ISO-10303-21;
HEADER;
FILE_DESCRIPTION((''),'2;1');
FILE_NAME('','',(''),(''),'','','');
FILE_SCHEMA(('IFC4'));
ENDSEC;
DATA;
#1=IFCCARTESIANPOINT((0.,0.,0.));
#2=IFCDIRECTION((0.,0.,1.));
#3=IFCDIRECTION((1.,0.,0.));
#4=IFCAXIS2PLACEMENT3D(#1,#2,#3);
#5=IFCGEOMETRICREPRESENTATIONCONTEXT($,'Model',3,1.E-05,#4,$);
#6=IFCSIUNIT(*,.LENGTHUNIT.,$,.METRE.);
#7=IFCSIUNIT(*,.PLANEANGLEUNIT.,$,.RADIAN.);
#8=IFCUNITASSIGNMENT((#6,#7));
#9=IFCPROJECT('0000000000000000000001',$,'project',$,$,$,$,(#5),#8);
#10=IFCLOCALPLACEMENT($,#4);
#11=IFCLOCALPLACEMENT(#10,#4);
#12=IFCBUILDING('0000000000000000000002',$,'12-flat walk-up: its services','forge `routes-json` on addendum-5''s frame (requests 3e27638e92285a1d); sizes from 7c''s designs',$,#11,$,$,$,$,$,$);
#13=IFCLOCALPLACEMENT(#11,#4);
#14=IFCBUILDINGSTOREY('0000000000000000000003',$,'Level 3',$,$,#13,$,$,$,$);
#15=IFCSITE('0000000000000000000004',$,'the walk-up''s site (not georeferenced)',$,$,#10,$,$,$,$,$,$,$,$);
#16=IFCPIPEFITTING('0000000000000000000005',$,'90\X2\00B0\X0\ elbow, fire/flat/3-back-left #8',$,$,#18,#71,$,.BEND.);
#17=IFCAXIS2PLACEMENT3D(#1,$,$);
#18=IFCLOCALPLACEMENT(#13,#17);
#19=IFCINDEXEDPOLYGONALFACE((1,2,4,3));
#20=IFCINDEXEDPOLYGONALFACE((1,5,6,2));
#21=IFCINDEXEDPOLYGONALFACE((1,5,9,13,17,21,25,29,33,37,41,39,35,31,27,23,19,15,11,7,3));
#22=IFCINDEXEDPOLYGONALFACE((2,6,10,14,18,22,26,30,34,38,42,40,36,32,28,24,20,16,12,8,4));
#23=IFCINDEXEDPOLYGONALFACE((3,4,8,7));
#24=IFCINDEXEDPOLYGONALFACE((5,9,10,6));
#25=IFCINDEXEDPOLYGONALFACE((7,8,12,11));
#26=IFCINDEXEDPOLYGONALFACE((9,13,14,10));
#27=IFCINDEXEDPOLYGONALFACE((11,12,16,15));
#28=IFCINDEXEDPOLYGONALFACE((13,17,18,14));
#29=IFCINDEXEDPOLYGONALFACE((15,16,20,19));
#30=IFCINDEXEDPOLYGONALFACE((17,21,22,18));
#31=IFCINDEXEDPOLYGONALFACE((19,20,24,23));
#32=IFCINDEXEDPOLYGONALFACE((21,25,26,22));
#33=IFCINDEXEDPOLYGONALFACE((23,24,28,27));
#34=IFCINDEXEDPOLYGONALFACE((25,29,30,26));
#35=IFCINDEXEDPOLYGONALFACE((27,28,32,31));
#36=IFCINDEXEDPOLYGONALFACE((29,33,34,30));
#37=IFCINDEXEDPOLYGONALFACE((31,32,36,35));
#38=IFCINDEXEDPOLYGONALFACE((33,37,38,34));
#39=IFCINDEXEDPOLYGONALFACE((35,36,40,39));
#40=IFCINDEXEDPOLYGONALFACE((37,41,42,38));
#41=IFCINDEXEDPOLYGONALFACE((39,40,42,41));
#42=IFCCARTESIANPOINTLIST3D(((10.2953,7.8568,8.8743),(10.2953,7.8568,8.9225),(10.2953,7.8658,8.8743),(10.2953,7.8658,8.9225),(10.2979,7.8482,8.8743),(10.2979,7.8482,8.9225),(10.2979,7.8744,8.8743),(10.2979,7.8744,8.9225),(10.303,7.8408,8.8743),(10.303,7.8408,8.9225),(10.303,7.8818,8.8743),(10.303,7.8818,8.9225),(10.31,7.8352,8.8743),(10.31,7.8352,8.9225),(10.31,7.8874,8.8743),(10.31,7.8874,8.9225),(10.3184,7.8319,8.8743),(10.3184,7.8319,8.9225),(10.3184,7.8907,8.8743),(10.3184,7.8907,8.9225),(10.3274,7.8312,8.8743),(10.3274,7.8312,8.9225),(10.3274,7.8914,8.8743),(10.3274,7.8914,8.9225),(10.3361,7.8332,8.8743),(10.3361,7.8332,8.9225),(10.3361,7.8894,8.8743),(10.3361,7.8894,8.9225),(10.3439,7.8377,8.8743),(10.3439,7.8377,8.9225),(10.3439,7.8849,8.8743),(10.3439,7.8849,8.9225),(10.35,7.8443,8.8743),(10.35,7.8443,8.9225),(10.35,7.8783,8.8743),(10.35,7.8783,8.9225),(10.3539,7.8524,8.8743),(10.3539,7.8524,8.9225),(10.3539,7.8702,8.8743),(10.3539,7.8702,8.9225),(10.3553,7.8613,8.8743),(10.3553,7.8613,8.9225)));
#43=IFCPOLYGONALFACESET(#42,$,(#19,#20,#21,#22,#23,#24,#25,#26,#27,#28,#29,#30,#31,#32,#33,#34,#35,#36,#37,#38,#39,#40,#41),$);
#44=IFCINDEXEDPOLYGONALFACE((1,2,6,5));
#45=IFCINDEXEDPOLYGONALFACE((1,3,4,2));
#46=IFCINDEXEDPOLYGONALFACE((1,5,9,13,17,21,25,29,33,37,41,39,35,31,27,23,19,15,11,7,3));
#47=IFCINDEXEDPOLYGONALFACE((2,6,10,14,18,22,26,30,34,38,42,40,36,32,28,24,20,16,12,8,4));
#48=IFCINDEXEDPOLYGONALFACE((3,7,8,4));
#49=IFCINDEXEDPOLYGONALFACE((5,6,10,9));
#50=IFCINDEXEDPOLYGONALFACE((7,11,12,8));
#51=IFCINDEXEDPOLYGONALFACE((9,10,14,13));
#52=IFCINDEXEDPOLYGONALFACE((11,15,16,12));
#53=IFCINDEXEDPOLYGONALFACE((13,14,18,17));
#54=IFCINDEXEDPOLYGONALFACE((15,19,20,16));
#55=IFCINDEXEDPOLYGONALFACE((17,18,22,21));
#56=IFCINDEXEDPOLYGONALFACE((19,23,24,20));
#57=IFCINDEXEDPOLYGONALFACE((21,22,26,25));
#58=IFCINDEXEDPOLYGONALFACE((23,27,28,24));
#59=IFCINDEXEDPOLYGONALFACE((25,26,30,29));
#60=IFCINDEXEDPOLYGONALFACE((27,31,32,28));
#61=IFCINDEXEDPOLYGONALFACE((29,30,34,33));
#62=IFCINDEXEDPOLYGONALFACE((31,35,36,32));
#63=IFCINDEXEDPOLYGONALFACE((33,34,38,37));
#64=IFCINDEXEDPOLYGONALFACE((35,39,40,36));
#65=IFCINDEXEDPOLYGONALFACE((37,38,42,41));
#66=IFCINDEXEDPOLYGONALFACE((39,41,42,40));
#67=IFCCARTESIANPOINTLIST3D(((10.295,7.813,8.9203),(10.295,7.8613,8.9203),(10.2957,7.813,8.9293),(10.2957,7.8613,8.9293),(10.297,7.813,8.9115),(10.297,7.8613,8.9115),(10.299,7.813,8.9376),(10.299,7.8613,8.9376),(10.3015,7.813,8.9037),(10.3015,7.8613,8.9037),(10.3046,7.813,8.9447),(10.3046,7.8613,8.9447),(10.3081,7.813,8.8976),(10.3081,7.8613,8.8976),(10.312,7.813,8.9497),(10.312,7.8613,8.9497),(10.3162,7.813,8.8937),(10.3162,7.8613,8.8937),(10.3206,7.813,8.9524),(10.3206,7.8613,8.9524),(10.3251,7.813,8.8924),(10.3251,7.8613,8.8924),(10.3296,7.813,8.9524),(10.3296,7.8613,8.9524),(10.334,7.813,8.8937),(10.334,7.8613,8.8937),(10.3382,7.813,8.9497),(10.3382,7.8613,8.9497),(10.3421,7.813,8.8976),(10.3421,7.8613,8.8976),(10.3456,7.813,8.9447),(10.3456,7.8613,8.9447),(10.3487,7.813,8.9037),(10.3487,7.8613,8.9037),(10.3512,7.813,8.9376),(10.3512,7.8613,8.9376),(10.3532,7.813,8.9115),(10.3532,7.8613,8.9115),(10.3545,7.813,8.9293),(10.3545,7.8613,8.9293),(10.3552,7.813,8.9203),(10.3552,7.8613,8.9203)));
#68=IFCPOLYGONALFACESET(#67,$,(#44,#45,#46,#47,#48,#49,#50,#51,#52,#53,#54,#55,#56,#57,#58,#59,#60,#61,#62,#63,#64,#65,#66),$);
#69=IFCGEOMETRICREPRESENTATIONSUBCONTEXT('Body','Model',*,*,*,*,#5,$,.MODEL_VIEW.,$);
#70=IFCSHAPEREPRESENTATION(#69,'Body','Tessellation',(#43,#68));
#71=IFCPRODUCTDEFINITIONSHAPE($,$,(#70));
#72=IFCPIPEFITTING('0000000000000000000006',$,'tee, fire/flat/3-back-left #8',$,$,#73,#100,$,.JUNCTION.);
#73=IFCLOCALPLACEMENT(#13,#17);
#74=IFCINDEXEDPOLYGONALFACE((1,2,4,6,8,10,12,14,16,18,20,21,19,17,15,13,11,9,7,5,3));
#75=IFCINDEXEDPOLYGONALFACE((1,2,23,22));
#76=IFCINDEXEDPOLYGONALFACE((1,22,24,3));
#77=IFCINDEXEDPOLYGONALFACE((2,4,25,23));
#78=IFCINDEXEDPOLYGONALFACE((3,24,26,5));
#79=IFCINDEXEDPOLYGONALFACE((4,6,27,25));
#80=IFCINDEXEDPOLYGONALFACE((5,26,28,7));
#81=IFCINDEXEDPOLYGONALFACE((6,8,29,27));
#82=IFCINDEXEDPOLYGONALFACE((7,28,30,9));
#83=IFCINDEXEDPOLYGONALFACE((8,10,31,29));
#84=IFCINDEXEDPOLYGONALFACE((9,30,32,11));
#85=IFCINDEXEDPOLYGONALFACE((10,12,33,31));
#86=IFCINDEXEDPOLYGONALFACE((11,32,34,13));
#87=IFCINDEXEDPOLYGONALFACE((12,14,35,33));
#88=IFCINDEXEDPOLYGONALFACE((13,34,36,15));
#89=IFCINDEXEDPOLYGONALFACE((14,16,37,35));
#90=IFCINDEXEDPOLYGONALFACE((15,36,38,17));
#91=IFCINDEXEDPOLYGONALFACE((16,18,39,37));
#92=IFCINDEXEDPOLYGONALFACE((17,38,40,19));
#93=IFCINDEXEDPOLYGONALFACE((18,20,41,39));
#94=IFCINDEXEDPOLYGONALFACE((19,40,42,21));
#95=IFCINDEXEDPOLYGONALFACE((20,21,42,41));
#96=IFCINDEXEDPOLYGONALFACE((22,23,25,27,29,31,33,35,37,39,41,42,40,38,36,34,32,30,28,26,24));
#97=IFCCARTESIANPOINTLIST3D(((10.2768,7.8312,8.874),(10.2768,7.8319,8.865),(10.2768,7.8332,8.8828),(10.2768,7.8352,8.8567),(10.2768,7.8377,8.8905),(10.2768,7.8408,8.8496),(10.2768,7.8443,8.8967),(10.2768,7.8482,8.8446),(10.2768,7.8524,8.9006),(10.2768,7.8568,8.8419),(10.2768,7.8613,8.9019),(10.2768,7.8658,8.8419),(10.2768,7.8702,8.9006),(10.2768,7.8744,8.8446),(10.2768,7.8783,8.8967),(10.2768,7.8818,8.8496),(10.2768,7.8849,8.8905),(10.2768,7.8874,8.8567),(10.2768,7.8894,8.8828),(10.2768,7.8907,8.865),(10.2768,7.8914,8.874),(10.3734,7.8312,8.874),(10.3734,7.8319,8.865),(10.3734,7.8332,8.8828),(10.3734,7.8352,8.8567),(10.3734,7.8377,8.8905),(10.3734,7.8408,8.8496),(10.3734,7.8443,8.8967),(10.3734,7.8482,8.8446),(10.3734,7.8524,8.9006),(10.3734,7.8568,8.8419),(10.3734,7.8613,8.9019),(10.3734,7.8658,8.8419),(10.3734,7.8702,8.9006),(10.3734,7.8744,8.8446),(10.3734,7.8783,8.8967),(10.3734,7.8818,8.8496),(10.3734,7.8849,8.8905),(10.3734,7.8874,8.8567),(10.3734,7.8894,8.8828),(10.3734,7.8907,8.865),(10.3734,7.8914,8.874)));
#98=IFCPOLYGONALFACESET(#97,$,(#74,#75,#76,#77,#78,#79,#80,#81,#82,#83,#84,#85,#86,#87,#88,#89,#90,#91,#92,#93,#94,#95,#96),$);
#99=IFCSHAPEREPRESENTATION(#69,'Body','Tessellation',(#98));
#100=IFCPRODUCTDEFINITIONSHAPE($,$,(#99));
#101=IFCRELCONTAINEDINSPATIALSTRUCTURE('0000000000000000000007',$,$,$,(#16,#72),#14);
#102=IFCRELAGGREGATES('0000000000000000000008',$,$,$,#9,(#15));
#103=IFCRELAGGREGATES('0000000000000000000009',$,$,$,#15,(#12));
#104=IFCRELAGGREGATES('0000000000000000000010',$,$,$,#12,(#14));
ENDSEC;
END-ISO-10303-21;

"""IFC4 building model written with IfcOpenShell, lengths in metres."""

from ifc_helpers import new_model, entity, si_unit, frame, origin_with_axes, place, context, subcontext, project, spatial, element, save


model = new_model("IFC4")

# Units and contexts
model_context = context("Model", 3, precision=1e-05, world=origin_with_axes())
body_context = subcontext(model_context, "Body", "Model", "MODEL_VIEW")
ifc_project = project(units=[si_unit("LENGTHUNIT", "METRE"), si_unit("PLANEANGLEUNIT", "RADIAN")], contexts=[model_context])

# Site, building, storey
site_placement = place(None, origin_with_axes())
site = spatial("IfcSite", under=ifc_project, at=site_placement, Name="the walk-up's site (not georeferenced)")
building_placement = place(site_placement, origin_with_axes())
building = spatial("IfcBuilding", under=site, at=building_placement, Name="12-flat walk-up: its services", Description="forge `routes-json` on addendum-5's frame (requests 3e27638e92285a1d); sizes from 7c's designs")
storey_placement = place(building_placement, origin_with_axes())
storey = spatial("IfcBuildingStorey", under=building, at=storey_placement, Name="Level 3")

# Pipe fittings
pipe_fitting_1_placement = place(storey_placement, frame((10.3251, 7.8613, 8.8743), z_axis=(0.0, 0.0, 1.0), x_axis=(1.0, 0.0, 0.0)))
element("IfcPipeFitting", 1, at=pipe_fitting_1_placement, inside=storey, Name="90° elbow, fire/flat/3-back-left #8", PredefinedType="BEND", context=body_context, shape_type="AdvancedSweptSolid", body=[
    entity("IfcSweptDiskSolid", entity("IfcPolyline", [entity("IfcCartesianPoint", [0.0, 0.0, 0.0]), entity("IfcCartesianPoint", [0.0, 0.0, 0.0483])]), 0.0302),
    entity("IfcSweptDiskSolid", entity("IfcPolyline", [entity("IfcCartesianPoint", [0.0, 0.0, 0.0483]), entity("IfcCartesianPoint", [0.0, -0.0483, 0.0483])]), 0.0302),
])
pipe_fitting_2_placement = place(storey_placement, frame((10.2768, 7.8613, 8.8717), z_axis=(0.0, 0.0, 1.0), x_axis=(1.0, 0.0, 0.0)))
element("IfcPipeFitting", 2, at=pipe_fitting_2_placement, inside=storey, Name="tee, fire/flat/3-back-left #8", PredefinedType="JUNCTION", context=body_context, shape_type="AdvancedSweptSolid", body=[
    entity("IfcSweptDiskSolid", entity("IfcPolyline", [entity("IfcCartesianPoint", [0.0, 0.0, 0.0]), entity("IfcCartesianPoint", [0.0965, 0.0, 0.0])]), 0.0302),
])

save(model, "model.ifc")
